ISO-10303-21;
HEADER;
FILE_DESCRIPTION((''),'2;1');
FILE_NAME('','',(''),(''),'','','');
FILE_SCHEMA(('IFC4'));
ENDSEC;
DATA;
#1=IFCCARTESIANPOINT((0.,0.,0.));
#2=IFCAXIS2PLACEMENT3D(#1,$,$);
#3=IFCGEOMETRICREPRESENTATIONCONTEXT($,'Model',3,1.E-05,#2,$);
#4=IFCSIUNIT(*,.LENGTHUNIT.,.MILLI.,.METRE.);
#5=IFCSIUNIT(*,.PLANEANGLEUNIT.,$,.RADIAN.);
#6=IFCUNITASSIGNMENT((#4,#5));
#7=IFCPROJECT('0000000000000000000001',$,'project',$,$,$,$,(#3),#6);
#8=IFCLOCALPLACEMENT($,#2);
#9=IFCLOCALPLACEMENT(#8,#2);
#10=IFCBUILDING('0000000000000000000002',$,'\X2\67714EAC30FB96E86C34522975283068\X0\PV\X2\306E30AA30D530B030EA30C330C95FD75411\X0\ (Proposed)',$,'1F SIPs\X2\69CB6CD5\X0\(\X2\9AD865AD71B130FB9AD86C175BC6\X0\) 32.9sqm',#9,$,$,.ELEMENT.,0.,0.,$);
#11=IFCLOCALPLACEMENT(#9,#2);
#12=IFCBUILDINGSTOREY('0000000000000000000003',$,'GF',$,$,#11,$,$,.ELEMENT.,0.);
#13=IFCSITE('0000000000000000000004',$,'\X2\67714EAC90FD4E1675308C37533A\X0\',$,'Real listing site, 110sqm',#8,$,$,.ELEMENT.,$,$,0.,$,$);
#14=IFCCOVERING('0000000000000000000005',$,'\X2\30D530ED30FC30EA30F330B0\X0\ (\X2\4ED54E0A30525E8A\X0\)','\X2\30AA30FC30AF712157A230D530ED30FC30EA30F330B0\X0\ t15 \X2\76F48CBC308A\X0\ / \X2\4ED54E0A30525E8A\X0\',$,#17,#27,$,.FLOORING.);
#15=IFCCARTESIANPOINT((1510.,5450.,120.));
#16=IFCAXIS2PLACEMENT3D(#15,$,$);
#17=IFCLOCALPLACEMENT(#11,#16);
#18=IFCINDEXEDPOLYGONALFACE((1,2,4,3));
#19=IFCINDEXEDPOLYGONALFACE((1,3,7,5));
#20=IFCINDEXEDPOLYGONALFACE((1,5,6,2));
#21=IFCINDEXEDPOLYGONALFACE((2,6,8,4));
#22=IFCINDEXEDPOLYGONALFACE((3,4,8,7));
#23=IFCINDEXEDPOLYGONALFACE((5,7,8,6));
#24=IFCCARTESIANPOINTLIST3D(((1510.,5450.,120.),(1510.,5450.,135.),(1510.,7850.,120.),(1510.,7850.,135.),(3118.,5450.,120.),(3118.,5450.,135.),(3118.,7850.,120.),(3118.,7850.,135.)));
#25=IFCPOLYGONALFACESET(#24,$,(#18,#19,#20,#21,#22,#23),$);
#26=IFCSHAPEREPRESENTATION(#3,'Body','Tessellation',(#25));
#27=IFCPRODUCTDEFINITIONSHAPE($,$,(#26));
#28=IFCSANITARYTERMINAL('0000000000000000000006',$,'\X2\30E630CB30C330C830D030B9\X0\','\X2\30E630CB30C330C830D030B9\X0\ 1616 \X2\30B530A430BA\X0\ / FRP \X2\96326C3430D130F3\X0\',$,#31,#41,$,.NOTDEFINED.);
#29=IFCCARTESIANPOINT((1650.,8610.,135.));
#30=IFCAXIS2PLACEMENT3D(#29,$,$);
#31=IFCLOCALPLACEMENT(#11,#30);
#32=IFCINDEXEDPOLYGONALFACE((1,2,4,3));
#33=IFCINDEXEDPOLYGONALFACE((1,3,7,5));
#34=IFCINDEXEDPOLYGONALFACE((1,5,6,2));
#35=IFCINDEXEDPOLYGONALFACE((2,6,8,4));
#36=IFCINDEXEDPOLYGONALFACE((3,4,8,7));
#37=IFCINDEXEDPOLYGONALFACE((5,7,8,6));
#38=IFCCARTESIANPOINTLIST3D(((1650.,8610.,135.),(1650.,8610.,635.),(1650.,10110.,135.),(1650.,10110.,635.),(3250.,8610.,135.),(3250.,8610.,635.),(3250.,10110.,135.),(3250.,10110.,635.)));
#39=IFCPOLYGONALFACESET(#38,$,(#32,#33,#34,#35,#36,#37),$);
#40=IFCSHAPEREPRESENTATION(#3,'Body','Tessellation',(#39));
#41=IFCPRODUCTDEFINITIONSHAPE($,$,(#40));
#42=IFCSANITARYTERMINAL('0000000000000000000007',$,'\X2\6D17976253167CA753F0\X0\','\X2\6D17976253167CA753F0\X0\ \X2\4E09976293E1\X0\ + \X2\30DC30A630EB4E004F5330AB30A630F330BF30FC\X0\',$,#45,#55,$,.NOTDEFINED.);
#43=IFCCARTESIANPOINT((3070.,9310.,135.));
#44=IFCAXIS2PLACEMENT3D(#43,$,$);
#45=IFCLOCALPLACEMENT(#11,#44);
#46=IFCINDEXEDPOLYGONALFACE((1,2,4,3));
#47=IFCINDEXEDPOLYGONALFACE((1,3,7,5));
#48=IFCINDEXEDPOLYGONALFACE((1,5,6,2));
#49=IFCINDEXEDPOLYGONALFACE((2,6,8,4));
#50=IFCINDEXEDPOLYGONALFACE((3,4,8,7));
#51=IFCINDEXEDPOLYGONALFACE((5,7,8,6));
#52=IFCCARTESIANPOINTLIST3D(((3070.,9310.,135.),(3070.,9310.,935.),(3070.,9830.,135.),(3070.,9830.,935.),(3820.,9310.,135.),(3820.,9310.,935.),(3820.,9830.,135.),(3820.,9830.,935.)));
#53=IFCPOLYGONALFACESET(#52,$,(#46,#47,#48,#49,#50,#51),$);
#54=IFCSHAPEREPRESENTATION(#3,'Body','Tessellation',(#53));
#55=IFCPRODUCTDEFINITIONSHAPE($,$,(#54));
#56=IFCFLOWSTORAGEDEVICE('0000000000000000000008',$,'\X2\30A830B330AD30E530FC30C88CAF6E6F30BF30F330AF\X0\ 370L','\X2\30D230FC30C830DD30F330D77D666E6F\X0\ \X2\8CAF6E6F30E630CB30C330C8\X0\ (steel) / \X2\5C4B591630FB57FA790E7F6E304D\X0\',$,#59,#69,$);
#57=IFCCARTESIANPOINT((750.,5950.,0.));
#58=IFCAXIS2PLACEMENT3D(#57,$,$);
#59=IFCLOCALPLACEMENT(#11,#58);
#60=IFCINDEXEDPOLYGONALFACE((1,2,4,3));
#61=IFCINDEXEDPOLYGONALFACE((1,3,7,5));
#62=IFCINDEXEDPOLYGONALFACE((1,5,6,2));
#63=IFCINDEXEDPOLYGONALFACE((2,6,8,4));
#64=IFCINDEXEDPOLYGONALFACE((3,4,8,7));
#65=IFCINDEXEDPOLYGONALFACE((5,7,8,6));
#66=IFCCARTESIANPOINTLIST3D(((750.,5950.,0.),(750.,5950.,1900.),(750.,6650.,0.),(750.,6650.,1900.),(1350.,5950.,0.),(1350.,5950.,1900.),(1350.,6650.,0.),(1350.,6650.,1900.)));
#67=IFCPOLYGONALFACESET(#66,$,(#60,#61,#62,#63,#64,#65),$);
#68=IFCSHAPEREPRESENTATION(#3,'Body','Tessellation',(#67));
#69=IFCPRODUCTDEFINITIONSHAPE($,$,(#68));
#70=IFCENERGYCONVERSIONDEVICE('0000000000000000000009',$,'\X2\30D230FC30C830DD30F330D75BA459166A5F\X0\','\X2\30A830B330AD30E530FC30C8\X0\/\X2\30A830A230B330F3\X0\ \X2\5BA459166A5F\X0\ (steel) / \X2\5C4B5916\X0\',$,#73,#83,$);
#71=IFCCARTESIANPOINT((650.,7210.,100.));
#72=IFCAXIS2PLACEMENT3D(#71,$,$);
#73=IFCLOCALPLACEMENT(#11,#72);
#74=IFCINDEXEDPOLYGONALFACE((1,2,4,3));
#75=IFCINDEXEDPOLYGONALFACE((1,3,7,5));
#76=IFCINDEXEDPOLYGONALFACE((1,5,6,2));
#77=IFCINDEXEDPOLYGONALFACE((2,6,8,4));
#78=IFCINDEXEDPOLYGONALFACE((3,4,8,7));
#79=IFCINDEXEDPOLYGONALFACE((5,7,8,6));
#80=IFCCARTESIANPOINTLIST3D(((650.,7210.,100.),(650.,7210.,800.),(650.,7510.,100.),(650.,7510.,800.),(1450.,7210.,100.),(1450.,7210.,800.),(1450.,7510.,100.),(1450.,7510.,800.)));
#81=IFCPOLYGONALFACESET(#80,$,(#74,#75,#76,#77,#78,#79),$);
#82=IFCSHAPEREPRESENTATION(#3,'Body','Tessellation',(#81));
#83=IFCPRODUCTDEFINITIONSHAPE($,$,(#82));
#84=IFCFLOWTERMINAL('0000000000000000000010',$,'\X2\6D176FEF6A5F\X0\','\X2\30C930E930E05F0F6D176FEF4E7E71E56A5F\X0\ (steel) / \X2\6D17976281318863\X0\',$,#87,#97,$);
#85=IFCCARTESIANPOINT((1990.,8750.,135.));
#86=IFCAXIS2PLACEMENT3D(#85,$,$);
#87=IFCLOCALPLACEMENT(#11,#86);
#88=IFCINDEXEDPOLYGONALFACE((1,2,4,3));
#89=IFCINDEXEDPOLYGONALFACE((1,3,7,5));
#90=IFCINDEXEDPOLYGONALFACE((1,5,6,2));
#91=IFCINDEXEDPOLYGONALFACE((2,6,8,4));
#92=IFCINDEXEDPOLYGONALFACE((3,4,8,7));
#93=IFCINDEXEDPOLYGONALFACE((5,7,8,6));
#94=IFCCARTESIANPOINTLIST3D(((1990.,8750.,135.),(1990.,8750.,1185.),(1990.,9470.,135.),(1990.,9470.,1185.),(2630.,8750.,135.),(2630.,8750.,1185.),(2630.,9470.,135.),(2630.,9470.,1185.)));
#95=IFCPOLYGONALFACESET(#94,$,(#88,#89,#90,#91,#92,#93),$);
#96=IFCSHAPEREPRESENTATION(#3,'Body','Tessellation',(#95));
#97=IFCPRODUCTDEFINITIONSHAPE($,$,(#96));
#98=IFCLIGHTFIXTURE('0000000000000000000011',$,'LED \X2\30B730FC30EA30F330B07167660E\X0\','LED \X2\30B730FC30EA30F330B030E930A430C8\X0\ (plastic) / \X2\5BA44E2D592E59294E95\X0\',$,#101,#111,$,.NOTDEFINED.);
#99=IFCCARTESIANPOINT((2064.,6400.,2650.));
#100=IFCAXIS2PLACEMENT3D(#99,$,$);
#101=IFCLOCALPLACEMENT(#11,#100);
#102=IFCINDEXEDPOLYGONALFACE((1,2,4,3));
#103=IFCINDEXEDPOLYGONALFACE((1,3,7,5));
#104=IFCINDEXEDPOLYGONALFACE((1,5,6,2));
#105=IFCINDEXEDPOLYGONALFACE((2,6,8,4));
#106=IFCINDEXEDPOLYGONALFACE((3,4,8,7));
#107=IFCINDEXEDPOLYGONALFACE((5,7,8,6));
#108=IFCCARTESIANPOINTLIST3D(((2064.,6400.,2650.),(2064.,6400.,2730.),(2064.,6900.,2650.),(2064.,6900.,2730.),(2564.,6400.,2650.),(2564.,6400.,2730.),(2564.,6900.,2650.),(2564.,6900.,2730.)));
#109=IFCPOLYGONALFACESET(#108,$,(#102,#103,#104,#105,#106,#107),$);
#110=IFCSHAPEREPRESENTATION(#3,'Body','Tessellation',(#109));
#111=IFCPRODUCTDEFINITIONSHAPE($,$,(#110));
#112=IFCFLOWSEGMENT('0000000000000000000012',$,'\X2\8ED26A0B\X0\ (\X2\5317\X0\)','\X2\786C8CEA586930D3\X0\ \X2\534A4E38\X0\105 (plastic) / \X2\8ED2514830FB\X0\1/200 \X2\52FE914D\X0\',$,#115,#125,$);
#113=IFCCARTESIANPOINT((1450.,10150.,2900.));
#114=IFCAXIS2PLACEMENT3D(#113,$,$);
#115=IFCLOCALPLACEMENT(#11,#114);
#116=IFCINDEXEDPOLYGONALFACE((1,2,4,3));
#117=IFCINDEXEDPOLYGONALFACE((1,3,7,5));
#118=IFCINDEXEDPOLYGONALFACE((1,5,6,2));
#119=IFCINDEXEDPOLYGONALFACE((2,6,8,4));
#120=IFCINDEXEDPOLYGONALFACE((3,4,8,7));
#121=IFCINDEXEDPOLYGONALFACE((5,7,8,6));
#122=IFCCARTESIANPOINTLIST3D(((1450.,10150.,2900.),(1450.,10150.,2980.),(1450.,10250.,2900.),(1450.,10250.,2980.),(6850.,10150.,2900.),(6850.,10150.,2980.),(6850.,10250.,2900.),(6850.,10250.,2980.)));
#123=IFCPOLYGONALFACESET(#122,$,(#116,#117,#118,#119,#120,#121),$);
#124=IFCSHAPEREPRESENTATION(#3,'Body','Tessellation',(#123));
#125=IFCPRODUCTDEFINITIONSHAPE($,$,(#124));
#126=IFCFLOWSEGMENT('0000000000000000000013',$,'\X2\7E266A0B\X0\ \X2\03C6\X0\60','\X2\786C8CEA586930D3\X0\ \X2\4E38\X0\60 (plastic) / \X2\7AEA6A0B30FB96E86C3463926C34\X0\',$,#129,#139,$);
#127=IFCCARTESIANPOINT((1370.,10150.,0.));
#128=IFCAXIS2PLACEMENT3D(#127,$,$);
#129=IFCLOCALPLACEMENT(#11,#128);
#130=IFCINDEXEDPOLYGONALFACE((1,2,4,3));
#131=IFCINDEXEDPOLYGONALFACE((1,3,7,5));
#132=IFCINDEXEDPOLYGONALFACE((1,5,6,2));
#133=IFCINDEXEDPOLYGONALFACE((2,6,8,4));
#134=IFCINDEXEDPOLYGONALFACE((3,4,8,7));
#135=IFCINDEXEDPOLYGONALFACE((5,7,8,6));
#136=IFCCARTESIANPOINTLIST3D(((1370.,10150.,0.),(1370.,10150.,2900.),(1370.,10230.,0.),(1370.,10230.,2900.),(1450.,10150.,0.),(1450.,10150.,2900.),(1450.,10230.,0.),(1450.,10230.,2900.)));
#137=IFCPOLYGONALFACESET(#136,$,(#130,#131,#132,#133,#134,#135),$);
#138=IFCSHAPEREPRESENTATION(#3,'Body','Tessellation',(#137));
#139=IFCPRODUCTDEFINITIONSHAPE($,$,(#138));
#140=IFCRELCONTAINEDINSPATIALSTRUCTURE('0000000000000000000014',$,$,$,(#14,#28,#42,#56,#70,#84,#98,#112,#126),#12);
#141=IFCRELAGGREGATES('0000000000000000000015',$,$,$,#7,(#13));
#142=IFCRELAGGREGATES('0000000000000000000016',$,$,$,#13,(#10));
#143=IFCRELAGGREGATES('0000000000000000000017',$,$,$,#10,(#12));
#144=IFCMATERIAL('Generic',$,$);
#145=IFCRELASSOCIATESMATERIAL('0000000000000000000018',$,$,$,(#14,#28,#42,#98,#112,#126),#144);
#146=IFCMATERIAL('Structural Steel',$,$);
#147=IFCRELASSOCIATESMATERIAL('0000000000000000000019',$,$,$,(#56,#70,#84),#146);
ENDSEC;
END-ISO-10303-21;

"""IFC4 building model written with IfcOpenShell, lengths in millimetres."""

from ifc_helpers import new_model, si_unit, frame, frame_2d, origin, place, context, project, spatial, rectangle, extrude, material, element, save


model = new_model("IFC4")

# Units and contexts
model_context = context("Model", 3, precision=1e-05, world=origin())
ifc_project = project(units=[si_unit("LENGTHUNIT", "METRE", prefix="MILLI"), si_unit("PLANEANGLEUNIT", "RADIAN")], contexts=[model_context])

# Site, building, storey
site_placement = place(None, origin())
site = spatial("IfcSite", under=ifc_project, at=site_placement, Name="東京都世田谷区", ObjectType="Real listing site, 110sqm", CompositionType="ELEMENT", RefElevation=0.0)
building_placement = place(site_placement, origin())
building = spatial("IfcBuilding", under=site, at=building_placement, Name="東京・雨水利用とPVのオフグリッド志向 (Proposed)", ObjectType="1F SIPs構法(高断熱・高気密) 32.9sqm", CompositionType="ELEMENT", ElevationOfRefHeight=0.0, ElevationOfTerrain=0.0)
storey_placement = place(building_placement, origin())
storey = spatial("IfcBuildingStorey", under=building, at=storey_placement, Name="GF", CompositionType="ELEMENT", Elevation=0.0)

# Shared definitions
ifc_material_1 = material(Name="Structural Steel")

# Covering
ifc_material_2 = material(Name="Generic")
covering_1_placement = place(storey_placement, frame((1510.0, 5450.0, 120.0)))
element("IfcCovering", 1, at=covering_1_placement, inside=storey, material=ifc_material_2, Name="フローリング (仕上げ床)", Description="オーク無垢フローリング t15 直貼り / 仕上げ床", PredefinedType="FLOORING", context=model_context, shape_type="SweptSolid", body=[
    extrude(rectangle(XDim=1608.0, YDim=2400.0, at=frame_2d((804.0, 1200.0))), frame((1510.0, 5450.0, 120.0)), (0.0, 0.0, 1.0), 15.0),
])

# Sanitary terminals
sanitary_terminal_1_placement = place(storey_placement, frame((1650.0, 8610.0, 135.0)))
element("IfcSanitaryTerminal", 2, at=sanitary_terminal_1_placement, inside=storey, material=ifc_material_2, Name="ユニットバス", Description="ユニットバス 1616 サイズ / FRP 防水パン", PredefinedType="NOTDEFINED", context=model_context, shape_type="SweptSolid", body=[
    extrude(rectangle(XDim=1600.0, YDim=1500.0, at=frame_2d((800.0, 750.0))), frame((1650.0, 8610.0, 135.0)), (0.0, 0.0, 1.0), 500.0),
])
sanitary_terminal_2_placement = place(storey_placement, frame((3070.0, 9310.0, 135.0)))
element("IfcSanitaryTerminal", 3, at=sanitary_terminal_2_placement, inside=storey, material=ifc_material_2, Name="洗面化粧台", Description="洗面化粧台 三面鏡 + ボウル一体カウンター", PredefinedType="NOTDEFINED", context=model_context, shape_type="SweptSolid", body=[
    extrude(rectangle(XDim=750.0, YDim=520.0, at=frame_2d((375.0, 260.0))), frame((3070.0, 9310.0, 135.0)), (0.0, 0.0, 1.0), 800.0),
])

# Flow storage device
flow_storage_device_placement = place(storey_placement, frame((750.0, 5950.0, 0.0)))
element("IfcFlowStorageDevice", 4, at=flow_storage_device_placement, inside=storey, material=ifc_material_1, Name="エコキュート貯湯タンク 370L", Description="ヒートポンプ給湯 貯湯ユニット (steel) / 屋外・基礎置き", context=model_context, shape_type="SweptSolid", body=[
    extrude(rectangle(XDim=600.0, YDim=700.0, at=frame_2d((300.0, 350.0))), frame((750.0, 5950.0, 0.0)), (0.0, 0.0, 1.0), 1900.0),
])

# Energy conversion device
energy_conversion_device_placement = place(storey_placement, frame((650.0, 7210.0, 100.0)))
element("IfcEnergyConversionDevice", 5, at=energy_conversion_device_placement, inside=storey, material=ifc_material_1, Name="ヒートポンプ室外機", Description="エコキュート/エアコン 室外機 (steel) / 屋外", context=model_context, shape_type="SweptSolid", body=[
    extrude(rectangle(XDim=800.0, YDim=300.0, at=frame_2d((400.0, 150.0))), frame((650.0, 7210.0, 100.0)), (0.0, 0.0, 1.0), 700.0),
])

# Flow terminal
flow_terminal_placement = place(storey_placement, frame((1990.0, 8750.0, 135.0)))
element("IfcFlowTerminal", 6, at=flow_terminal_placement, inside=storey, material=ifc_material_1, Name="洗濯機", Description="ドラム式洗濯乾燥機 (steel) / 洗面脱衣", context=model_context, shape_type="SweptSolid", body=[
    extrude(rectangle(XDim=640.0, YDim=720.0, at=frame_2d((320.0, 360.0))), frame((1990.0, 8750.0, 135.0)), (0.0, 0.0, 1.0), 1050.0),
])

# Light fixture
light_fixture_placement = place(storey_placement, frame((2064.0, 6400.0, 2650.0)))
element("IfcLightFixture", 7, at=light_fixture_placement, inside=storey, material=ifc_material_2, Name="LED シーリング照明", Description="LED シーリングライト (plastic) / 室中央天井", PredefinedType="NOTDEFINED", context=model_context, shape_type="SweptSolid", body=[
    extrude(rectangle(XDim=500.0, YDim=500.0, at=frame_2d((250.0, 250.0))), frame((2064.0, 6400.0, 2650.0)), (0.0, 0.0, 1.0), 80.0),
])

# Flow segments
flow_segment_1_placement = place(storey_placement, frame((1450.0, 10150.0, 2900.0)))
element("IfcFlowSegment", 8, at=flow_segment_1_placement, inside=storey, material=ifc_material_2, Name="軒樋 (北)", Description="硬質塩ビ 半丸105 (plastic) / 軒先・1/200 勾配", context=model_context, shape_type="SweptSolid", body=[
    extrude(rectangle(XDim=5400.0, YDim=100.0, at=frame_2d((2700.0, 50.0))), frame((1450.0, 10150.0, 2900.0)), (0.0, 0.0, 1.0), 80.0),
])
flow_segment_2_placement = place(storey_placement, frame((1370.0, 10150.0, 0.0)))
element("IfcFlowSegment", 9, at=flow_segment_2_placement, inside=storey, material=ifc_material_2, Name="縦樋 φ60", Description="硬質塩ビ 丸60 (plastic) / 竪樋・雨水排水", context=model_context, shape_type="SweptSolid", body=[
    extrude(rectangle(XDim=80.0, YDim=80.0, at=frame_2d((40.0, 40.0))), frame((1370.0, 10150.0, 0.0)), (0.0, 0.0, 1.0), 2900.0),
])

save(model, "model.ifc")
